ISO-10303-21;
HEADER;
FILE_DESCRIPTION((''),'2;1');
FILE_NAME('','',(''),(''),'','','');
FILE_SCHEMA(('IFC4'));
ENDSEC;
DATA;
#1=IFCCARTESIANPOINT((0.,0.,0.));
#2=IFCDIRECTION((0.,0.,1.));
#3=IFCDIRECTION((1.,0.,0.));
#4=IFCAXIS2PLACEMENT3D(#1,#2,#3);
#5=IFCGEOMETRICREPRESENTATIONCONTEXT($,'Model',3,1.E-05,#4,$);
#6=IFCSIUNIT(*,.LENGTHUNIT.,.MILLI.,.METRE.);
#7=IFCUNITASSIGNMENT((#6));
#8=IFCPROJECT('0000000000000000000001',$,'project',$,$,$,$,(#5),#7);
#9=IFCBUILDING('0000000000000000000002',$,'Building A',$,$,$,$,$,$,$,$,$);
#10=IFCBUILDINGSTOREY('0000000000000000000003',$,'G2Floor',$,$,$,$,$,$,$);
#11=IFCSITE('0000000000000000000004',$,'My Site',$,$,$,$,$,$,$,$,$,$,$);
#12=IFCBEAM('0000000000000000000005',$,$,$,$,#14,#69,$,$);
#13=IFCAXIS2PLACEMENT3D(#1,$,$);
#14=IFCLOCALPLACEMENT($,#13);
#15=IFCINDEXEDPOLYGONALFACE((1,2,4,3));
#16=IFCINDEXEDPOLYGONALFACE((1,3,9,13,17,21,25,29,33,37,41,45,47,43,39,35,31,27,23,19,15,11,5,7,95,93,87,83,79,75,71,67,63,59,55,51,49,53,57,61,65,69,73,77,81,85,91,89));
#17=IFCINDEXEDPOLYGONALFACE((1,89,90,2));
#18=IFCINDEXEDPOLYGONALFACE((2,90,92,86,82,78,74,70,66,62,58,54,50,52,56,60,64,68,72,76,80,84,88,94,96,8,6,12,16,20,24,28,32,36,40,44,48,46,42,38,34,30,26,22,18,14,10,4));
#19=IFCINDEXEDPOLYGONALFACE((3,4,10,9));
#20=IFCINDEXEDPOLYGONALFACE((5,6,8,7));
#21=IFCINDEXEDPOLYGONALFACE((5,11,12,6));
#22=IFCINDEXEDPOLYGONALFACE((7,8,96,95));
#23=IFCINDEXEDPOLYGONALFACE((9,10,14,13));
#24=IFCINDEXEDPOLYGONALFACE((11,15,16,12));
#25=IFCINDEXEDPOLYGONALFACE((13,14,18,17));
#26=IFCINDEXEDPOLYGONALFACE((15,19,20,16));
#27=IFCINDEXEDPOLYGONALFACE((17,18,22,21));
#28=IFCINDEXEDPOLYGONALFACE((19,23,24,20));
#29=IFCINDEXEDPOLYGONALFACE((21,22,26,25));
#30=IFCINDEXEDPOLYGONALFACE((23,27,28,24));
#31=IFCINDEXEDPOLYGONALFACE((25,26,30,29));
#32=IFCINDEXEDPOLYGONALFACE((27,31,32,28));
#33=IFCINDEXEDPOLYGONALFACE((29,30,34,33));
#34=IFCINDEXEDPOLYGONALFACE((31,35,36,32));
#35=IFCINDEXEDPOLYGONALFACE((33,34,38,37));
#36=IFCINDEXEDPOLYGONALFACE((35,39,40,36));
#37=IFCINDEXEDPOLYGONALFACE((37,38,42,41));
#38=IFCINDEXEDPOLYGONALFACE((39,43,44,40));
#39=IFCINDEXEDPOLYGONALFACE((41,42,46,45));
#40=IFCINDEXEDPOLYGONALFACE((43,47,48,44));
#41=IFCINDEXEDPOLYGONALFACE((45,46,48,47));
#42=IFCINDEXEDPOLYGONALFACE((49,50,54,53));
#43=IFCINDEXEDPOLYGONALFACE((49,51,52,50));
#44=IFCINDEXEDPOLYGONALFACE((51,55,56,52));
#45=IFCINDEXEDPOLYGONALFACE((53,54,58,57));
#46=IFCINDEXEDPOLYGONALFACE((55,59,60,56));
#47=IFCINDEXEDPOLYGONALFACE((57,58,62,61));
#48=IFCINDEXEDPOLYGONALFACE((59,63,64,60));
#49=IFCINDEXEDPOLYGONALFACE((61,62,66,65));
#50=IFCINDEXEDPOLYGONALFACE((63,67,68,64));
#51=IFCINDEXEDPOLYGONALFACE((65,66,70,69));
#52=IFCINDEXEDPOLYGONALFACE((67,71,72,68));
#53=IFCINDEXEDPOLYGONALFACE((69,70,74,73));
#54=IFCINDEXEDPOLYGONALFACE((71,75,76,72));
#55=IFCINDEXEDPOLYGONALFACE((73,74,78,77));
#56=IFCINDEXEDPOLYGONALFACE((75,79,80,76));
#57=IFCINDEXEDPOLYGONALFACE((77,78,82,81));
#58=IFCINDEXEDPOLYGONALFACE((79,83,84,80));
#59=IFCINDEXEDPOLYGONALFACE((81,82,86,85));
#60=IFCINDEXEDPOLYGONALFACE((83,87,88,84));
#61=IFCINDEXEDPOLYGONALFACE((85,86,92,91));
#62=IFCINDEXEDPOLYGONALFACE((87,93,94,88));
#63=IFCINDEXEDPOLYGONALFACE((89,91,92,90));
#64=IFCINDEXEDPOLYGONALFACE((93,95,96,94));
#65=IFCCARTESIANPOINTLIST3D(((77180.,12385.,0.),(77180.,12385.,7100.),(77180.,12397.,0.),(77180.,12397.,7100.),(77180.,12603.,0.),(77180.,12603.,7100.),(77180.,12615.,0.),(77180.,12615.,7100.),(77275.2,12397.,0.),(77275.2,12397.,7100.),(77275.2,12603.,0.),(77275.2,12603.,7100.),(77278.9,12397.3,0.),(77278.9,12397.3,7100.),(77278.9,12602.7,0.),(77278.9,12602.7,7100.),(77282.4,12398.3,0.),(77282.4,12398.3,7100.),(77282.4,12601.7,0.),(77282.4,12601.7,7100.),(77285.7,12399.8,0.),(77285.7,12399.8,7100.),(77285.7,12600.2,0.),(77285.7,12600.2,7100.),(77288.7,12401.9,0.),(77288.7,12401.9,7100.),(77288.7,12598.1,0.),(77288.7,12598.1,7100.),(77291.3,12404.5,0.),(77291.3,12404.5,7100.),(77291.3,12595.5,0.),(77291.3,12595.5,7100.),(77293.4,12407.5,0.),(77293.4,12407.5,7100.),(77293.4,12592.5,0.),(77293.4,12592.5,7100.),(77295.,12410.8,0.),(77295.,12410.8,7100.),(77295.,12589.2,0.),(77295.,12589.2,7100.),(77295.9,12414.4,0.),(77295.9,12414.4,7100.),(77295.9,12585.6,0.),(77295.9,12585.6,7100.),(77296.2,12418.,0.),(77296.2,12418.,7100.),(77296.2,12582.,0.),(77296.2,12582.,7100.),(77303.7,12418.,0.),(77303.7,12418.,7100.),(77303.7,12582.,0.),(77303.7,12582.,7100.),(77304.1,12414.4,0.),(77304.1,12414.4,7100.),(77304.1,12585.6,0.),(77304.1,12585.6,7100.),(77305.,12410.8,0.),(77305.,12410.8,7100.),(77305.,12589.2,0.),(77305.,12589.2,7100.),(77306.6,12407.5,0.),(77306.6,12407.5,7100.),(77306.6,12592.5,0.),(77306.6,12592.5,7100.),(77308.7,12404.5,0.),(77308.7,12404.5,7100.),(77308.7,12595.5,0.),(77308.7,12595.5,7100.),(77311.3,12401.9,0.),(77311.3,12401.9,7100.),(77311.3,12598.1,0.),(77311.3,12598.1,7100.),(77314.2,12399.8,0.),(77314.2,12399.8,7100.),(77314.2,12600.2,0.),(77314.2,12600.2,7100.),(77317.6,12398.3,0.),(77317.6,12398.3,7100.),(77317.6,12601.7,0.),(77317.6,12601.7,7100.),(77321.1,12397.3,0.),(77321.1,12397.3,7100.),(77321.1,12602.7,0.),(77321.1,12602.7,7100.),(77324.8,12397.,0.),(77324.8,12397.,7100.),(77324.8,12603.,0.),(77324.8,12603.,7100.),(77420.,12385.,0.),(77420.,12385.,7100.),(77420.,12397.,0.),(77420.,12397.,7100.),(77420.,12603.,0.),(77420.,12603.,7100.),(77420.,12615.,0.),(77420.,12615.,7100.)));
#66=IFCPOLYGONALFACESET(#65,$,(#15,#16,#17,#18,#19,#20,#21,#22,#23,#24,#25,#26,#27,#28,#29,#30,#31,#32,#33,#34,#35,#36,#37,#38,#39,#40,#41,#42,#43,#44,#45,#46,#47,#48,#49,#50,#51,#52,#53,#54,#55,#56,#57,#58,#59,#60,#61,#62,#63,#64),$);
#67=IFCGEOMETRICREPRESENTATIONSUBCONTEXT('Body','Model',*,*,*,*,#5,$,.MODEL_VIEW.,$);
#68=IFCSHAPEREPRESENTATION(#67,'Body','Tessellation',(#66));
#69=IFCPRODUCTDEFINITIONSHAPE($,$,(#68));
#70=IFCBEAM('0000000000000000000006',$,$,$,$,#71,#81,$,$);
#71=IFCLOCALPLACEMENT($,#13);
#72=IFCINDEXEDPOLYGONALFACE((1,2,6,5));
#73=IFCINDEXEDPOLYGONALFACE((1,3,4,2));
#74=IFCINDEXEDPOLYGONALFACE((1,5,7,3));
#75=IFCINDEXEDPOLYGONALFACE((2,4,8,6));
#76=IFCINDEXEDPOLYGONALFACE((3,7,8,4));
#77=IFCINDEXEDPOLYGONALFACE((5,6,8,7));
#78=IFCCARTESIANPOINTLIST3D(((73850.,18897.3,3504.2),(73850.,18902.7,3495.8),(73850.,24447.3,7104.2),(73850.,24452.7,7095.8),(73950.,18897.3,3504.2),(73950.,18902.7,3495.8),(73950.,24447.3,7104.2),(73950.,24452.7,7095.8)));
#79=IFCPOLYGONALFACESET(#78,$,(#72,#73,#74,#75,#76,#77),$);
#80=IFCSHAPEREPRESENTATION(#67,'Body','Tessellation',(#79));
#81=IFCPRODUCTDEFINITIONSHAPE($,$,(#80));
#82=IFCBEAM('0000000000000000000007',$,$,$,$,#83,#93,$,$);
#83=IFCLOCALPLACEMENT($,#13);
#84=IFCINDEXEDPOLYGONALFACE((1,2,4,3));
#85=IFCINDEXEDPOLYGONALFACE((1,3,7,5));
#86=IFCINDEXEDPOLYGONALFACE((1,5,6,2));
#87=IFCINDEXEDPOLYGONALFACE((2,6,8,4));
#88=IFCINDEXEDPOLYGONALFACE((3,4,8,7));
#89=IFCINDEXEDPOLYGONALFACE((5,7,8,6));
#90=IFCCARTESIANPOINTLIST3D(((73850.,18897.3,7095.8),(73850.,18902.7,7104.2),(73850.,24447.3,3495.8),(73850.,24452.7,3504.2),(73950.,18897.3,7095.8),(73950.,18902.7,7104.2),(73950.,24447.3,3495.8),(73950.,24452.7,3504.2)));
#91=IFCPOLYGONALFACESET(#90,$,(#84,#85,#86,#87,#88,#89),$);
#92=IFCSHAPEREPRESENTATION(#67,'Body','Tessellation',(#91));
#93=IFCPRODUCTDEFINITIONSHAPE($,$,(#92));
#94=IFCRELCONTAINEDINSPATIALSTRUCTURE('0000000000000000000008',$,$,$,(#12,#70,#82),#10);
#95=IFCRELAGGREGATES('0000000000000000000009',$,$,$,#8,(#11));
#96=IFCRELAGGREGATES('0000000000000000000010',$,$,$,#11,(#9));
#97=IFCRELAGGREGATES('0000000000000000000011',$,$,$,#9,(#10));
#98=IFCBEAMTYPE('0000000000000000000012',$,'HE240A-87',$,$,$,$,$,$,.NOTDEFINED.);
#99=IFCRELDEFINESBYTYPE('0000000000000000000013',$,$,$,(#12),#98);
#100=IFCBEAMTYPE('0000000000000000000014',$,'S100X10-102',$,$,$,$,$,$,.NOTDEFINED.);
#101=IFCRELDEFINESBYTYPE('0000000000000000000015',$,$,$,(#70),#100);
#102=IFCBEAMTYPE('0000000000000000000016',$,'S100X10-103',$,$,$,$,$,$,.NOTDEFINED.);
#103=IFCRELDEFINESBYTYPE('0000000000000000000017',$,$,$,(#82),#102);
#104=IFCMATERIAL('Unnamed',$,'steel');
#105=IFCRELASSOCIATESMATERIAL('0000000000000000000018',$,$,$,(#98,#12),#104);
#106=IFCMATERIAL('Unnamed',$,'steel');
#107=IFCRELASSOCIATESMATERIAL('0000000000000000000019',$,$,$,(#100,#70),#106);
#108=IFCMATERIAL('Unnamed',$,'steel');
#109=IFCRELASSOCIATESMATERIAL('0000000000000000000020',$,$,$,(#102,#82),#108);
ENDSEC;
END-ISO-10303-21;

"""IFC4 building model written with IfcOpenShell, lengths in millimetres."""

from ifc_helpers import new_model, si_unit, frame, origin_with_axes, place, context, subcontext, project, spatial, polyline, outline, extrude, material, material_profile, profile_set, profile_usage, type_object, element, save


model = new_model("IFC4")

# Units and contexts
model_context = context("Model", 3, precision=1e-05, world=origin_with_axes())
body_context = subcontext(model_context, "Body", "Model", "MODEL_VIEW")
ifc_project = project(units=[si_unit("LENGTHUNIT", "METRE", prefix="MILLI")], contexts=[model_context])

# Site, building, storey
site = spatial("IfcSite", under=ifc_project, Name="My Site")
building = spatial("IfcBuilding", under=site, Name="Building A")
storey = spatial("IfcBuildingStorey", under=building, Name="G2Floor")

# Beams
ifc_material_1 = material(Name="Unnamed", Category="steel")
ifc_material_profile_1 = material_profile(ifc_material_1, outline(polyline([(120.0, -115.0), (120.0, -103.0), (120.0, -103.0), (24.8, -103.0), (24.8, -103.0), (21.1, -102.7), (21.1, -102.7), (17.6, -101.7), (17.6, -101.7), (14.2, -100.2), (14.2, -100.2), (11.3, -98.1), (11.3, -98.1), (8.7, -95.5), (8.7, -95.5), (6.6, -92.5), (6.6, -92.5), (5.0, -89.2), (5.0, -89.2), (4.1, -85.6), (4.1, -85.6), (3.8, -82.0), (3.8, -82.0), (3.8, 82.0), (3.8, 82.0), (4.1, 85.6), (4.1, 85.6), (5.0, 89.2), (5.0, 89.2), (6.6, 92.5), (6.6, 92.5), (8.7, 95.5), (8.7, 95.5), (11.3, 98.1), (11.3, 98.1), (14.2, 100.2), (14.2, 100.2), (17.6, 101.7), (17.6, 101.7), (21.1, 102.7), (21.1, 102.7), (24.8, 103.0), (24.8, 103.0), (120.0, 103.0), (120.0, 103.0), (120.0, 115.0), (120.0, 115.0), (-120.0, 115.0), (-120.0, 115.0), (-120.0, 103.0), (-120.0, 103.0), (-24.8, 103.0), (-24.8, 103.0), (-21.1, 102.7), (-21.1, 102.7), (-17.6, 101.7), (-17.6, 101.7), (-14.2, 100.2), (-14.2, 100.2), (-11.3, 98.1), (-11.3, 98.1), (-8.7, 95.5), (-8.7, 95.5), (-6.6, 92.5), (-6.6, 92.5), (-5.0, 89.2), (-5.0, 89.2), (-4.1, 85.6), (-4.1, 85.6), (-3.8, 82.0), (-3.8, 82.0), (-3.8, -82.0), (-3.8, -82.0), (-4.1, -85.6), (-4.1, -85.6), (-5.0, -89.2), (-5.0, -89.2), (-6.6, -92.5), (-6.6, -92.5), (-8.7, -95.5), (-8.7, -95.5), (-11.3, -98.1), (-11.3, -98.1), (-14.2, -100.2), (-14.2, -100.2), (-17.6, -101.7), (-17.6, -101.7), (-21.1, -102.7), (-21.1, -102.7), (-24.8, -103.0), (-24.8, -103.0), (-120.0, -103.0), (-120.0, -103.0), (-120.0, -115.0), (-120.0, -115.0), (120.0, -115.0)])))
ifc_profile_set_1 = profile_set([ifc_material_profile_1], Name="HE240A-87")
ifc_profile_usage_1 = profile_usage(ifc_profile_set_1)
beam_type_1 = type_object("IfcBeamType", Name="HE240A-87", PredefinedType="NOTDEFINED", material=ifc_profile_set_1)
beam_1_placement = place(None, frame((77300.0, 12500.0, 0.0), z_axis=(0.0, 0.0, 1.0), x_axis=(1.0, 0.0, 0.0)))
element("IfcBeam", 1, at=beam_1_placement, inside=storey, type_object=beam_type_1, material=ifc_profile_usage_1, context=body_context, shape_type="SweptSolid", body=[
    extrude(outline(polyline([(120.0, -115.0), (120.0, -103.0), (120.0, -103.0), (24.8, -103.0), (24.8, -103.0), (21.1, -102.7), (21.1, -102.7), (17.6, -101.7), (17.6, -101.7), (14.2, -100.2), (14.2, -100.2), (11.3, -98.1), (11.3, -98.1), (8.7, -95.5), (8.7, -95.5), (6.6, -92.5), (6.6, -92.5), (5.0, -89.2), (5.0, -89.2), (4.1, -85.6), (4.1, -85.6), (3.8, -82.0), (3.8, -82.0), (3.8, 82.0), (3.8, 82.0), (4.1, 85.6), (4.1, 85.6), (5.0, 89.2), (5.0, 89.2), (6.6, 92.5), (6.6, 92.5), (8.7, 95.5), (8.7, 95.5), (11.3, 98.1), (11.3, 98.1), (14.2, 100.2), (14.2, 100.2), (17.6, 101.7), (17.6, 101.7), (21.1, 102.7), (21.1, 102.7), (24.8, 103.0), (24.8, 103.0), (120.0, 103.0), (120.0, 103.0), (120.0, 115.0), (120.0, 115.0), (-120.0, 115.0), (-120.0, 115.0), (-120.0, 103.0), (-120.0, 103.0), (-24.8, 103.0), (-24.8, 103.0), (-21.1, 102.7), (-21.1, 102.7), (-17.6, 101.7), (-17.6, 101.7), (-14.2, 100.2), (-14.2, 100.2), (-11.3, 98.1), (-11.3, 98.1), (-8.7, 95.5), (-8.7, 95.5), (-6.6, 92.5), (-6.6, 92.5), (-5.0, 89.2), (-5.0, 89.2), (-4.1, 85.6), (-4.1, 85.6), (-3.8, 82.0), (-3.8, 82.0), (-3.8, -82.0), (-3.8, -82.0), (-4.1, -85.6), (-4.1, -85.6), (-5.0, -89.2), (-5.0, -89.2), (-6.6, -92.5), (-6.6, -92.5), (-8.7, -95.5), (-8.7, -95.5), (-11.3, -98.1), (-11.3, -98.1), (-14.2, -100.2), (-14.2, -100.2), (-17.6, -101.7), (-17.6, -101.7), (-21.1, -102.7), (-21.1, -102.7), (-24.8, -103.0), (-24.8, -103.0), (-120.0, -103.0), (-120.0, -103.0), (-120.0, -115.0), (-120.0, -115.0), (120.0, -115.0)])), origin_with_axes(), (0.0, 0.0, 1.0), 7100.0),
])
ifc_material_2 = material(Name="Unnamed", Category="steel")
ifc_material_profile_2 = material_profile(ifc_material_2, outline(polyline([(50.0, -5.0), (50.0, 5.0), (50.0, 5.0), (-50.0, 5.0), (-50.0, 5.0), (-50.0, -5.0), (-50.0, -5.0), (50.0, -5.0)])))
ifc_profile_set_2 = profile_set([ifc_material_profile_2], Name="S100X10-102")
ifc_profile_usage_2 = profile_usage(ifc_profile_set_2)
beam_type_2 = type_object("IfcBeamType", Name="S100X10-102", PredefinedType="NOTDEFINED", material=ifc_profile_set_2)
beam_2_placement = place(None, frame((73900.0, 18900.0, 3500.0), z_axis=(0.0, 0.838961, 0.544191), x_axis=(1.0, 0.0, 0.0)))
element("IfcBeam", 2, at=beam_2_placement, inside=storey, type_object=beam_type_2, material=ifc_profile_usage_2, context=body_context, shape_type="SweptSolid", body=[
    extrude(outline(polyline([(50.0, -5.0), (50.0, 5.0), (50.0, 5.0), (-50.0, 5.0), (-50.0, 5.0), (-50.0, -5.0), (-50.0, -5.0), (50.0, -5.0)])), origin_with_axes(), (0.0, 0.0, 1.0), 6615.3),
])
ifc_material_3 = material(Name="Unnamed", Category="steel")
ifc_material_profile_3 = material_profile(ifc_material_3, outline(polyline([(50.0, -5.0), (50.0, 5.0), (50.0, 5.0), (-50.0, 5.0), (-50.0, 5.0), (-50.0, -5.0), (-50.0, -5.0), (50.0, -5.0)])))
ifc_profile_set_3 = profile_set([ifc_material_profile_3], Name="S100X10-103")
ifc_profile_usage_3 = profile_usage(ifc_profile_set_3)
beam_type_3 = type_object("IfcBeamType", Name="S100X10-103", PredefinedType="NOTDEFINED", material=ifc_profile_set_3)
beam_3_placement = place(None, frame((73900.0, 18900.0, 7100.0), z_axis=(0.0, 0.838961, -0.544191), x_axis=(1.0, 0.0, 0.0)))
element("IfcBeam", 3, at=beam_3_placement, inside=storey, type_object=beam_type_3, material=ifc_profile_usage_3, context=body_context, shape_type="SweptSolid", body=[
    extrude(outline(polyline([(50.0, -5.0), (50.0, 5.0), (50.0, 5.0), (-50.0, 5.0), (-50.0, 5.0), (-50.0, -5.0), (-50.0, -5.0), (50.0, -5.0)])), origin_with_axes(), (0.0, 0.0, 1.0), 6615.3),
])

save(model, "model.ifc")
